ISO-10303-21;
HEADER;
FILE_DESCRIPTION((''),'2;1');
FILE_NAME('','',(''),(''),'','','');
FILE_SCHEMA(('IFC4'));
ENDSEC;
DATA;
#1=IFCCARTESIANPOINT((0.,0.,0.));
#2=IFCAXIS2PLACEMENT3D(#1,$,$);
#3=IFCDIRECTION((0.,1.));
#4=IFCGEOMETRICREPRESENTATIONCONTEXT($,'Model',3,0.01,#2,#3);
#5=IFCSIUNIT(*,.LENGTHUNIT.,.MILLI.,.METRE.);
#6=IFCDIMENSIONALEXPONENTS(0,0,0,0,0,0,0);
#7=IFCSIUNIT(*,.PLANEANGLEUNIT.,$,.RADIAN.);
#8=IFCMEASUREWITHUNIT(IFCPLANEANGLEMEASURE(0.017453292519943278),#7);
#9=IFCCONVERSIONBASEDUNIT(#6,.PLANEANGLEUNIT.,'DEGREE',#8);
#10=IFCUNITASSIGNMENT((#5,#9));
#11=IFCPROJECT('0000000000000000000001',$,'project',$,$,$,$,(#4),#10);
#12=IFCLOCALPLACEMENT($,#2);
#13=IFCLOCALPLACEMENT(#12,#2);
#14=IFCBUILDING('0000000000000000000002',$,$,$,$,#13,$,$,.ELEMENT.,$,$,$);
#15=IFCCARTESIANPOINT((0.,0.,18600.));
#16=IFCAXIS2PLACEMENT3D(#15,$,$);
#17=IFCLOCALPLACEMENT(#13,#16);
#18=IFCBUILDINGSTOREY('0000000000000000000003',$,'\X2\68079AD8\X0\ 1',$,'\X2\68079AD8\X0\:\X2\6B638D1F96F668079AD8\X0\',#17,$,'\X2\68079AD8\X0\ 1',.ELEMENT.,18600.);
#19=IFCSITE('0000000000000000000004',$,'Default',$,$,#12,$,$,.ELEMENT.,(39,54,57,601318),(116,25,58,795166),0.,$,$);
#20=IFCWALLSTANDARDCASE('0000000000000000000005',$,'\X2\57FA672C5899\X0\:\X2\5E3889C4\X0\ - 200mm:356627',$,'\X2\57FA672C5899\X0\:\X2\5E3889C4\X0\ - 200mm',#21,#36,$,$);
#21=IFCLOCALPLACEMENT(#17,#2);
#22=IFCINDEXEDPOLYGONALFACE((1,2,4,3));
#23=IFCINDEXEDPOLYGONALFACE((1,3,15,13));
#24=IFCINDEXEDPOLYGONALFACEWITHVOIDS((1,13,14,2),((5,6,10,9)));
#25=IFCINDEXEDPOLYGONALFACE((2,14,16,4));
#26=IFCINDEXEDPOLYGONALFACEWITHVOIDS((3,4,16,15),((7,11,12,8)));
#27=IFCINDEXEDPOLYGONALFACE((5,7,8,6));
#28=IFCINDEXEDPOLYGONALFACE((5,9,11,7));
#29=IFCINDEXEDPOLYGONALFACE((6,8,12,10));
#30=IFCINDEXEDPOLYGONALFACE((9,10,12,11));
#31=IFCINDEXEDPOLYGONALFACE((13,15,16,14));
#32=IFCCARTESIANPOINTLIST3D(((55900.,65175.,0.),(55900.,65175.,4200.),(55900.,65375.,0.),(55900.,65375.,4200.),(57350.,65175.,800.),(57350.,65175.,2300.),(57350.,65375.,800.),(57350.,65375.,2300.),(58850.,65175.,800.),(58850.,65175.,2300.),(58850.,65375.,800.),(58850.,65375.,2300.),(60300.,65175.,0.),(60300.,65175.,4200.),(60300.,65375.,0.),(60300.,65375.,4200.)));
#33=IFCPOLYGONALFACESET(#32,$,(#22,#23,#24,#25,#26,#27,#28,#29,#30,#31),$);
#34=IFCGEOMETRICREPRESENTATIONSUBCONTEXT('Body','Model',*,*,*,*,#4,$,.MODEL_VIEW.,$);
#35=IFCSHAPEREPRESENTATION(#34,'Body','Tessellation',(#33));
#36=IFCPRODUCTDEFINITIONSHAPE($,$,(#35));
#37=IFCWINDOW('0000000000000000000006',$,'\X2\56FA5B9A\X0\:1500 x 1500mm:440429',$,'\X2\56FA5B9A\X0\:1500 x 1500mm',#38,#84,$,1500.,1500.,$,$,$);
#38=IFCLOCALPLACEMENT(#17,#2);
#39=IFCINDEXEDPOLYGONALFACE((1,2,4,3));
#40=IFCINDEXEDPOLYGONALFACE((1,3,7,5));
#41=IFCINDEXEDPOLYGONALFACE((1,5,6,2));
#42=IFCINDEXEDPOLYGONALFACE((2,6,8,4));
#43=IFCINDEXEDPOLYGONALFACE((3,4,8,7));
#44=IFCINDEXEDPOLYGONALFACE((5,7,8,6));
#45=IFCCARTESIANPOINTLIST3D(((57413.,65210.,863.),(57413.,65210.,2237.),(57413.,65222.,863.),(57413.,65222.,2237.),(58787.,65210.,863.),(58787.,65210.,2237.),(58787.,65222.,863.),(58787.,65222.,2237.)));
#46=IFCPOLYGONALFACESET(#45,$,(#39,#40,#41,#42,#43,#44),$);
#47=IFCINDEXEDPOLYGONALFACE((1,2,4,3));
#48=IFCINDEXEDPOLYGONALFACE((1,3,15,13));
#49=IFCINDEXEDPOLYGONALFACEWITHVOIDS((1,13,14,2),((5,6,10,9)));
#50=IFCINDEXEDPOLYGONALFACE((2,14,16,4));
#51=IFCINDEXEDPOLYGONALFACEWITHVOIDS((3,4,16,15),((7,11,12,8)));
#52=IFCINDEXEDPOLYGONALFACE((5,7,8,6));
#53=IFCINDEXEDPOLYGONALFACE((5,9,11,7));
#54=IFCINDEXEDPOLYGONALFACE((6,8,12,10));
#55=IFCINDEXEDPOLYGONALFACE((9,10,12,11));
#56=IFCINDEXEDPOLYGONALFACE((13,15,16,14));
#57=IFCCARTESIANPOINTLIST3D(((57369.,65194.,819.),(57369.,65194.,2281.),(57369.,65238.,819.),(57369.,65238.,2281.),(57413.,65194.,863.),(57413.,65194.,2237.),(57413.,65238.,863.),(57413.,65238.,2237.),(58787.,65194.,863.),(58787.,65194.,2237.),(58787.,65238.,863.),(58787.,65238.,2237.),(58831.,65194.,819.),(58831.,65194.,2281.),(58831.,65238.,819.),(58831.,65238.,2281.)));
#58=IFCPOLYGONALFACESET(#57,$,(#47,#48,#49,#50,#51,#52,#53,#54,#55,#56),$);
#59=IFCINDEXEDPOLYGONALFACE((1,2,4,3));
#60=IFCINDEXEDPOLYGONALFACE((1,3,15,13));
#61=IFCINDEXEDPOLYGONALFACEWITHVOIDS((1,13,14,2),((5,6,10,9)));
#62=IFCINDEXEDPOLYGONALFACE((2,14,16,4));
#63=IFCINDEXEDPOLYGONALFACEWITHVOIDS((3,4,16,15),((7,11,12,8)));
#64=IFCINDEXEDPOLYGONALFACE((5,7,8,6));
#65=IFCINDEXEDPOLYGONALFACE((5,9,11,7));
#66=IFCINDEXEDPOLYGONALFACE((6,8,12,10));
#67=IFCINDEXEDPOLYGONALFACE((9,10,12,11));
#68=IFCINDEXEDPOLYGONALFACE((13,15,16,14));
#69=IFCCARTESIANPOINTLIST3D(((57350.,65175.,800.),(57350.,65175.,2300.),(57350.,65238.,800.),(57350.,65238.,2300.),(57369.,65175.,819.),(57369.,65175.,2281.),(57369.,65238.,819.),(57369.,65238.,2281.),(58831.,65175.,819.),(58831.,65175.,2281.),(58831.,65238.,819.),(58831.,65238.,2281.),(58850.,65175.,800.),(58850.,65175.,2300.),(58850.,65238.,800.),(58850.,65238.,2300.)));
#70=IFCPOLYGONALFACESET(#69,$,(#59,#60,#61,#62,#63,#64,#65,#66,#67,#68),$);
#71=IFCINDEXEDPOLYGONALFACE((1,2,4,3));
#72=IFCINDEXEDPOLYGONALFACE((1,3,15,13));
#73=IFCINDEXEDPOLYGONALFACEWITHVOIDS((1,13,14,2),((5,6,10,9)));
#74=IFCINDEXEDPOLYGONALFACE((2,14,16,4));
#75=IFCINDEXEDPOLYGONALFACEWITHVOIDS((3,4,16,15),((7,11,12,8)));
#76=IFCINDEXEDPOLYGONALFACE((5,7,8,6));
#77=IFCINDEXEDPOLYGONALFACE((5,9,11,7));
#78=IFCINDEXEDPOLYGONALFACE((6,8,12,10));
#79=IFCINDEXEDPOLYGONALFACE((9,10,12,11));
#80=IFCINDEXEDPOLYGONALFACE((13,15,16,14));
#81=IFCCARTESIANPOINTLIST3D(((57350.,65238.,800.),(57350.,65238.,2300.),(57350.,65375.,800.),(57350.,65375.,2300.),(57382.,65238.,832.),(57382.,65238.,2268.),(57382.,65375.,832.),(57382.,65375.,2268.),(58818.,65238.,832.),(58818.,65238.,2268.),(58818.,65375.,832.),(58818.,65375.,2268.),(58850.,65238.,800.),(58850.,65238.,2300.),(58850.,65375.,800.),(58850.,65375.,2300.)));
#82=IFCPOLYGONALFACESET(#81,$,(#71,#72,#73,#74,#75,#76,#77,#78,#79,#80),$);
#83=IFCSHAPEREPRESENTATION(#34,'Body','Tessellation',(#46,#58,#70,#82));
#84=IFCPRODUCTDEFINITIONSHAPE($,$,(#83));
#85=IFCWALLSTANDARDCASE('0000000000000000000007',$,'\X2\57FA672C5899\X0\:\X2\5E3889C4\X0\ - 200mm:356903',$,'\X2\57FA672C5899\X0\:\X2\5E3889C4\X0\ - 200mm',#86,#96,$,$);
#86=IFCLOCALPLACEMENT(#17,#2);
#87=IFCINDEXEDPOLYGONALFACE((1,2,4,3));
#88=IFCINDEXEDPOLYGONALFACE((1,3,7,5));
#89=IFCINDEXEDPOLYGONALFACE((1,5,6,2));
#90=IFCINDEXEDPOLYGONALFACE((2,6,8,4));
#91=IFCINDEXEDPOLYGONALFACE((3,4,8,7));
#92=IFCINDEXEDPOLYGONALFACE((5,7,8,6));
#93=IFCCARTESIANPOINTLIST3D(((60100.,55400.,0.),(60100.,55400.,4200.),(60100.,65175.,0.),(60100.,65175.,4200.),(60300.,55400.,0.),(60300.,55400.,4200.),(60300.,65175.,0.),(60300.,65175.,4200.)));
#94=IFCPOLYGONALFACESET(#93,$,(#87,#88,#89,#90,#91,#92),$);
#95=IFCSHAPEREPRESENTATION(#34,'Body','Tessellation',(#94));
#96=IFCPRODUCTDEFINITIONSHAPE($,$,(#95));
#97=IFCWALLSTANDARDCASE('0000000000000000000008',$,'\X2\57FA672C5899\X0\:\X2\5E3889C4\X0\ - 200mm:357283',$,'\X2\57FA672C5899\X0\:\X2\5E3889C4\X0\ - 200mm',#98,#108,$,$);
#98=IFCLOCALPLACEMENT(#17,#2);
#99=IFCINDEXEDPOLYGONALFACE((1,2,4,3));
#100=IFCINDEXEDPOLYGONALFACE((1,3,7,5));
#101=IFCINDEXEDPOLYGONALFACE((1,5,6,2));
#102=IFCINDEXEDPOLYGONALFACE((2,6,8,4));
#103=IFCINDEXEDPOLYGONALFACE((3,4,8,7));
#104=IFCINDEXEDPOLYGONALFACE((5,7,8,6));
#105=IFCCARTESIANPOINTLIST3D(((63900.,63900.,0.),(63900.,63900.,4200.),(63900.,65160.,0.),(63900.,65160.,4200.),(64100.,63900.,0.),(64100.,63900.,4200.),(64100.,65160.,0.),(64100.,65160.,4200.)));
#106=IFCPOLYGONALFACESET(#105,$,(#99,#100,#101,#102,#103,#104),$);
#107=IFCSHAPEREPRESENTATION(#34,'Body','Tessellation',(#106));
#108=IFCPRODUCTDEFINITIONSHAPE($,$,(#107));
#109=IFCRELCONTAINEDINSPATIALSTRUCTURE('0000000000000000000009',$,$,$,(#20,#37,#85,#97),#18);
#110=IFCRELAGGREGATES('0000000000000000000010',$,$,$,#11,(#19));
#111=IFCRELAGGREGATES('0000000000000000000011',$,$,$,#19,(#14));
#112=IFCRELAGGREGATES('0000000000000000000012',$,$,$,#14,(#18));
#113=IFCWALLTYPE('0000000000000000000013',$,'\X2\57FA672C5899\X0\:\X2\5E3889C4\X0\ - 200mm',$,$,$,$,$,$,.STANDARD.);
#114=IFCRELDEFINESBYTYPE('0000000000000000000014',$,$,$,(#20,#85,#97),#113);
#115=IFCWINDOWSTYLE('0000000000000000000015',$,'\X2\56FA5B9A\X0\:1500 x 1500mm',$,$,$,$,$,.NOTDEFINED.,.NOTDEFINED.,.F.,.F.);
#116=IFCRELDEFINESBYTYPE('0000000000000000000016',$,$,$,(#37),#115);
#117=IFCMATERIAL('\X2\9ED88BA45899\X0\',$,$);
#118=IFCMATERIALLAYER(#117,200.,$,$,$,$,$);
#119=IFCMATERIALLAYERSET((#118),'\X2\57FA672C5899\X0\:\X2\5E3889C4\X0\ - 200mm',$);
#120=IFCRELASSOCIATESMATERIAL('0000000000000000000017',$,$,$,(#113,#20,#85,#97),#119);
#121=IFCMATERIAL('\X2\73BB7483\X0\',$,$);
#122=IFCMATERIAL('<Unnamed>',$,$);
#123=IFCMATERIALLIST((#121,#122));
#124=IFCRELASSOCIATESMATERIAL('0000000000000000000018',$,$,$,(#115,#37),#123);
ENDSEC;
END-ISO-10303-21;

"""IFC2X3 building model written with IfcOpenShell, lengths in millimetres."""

from ifc_helpers import new_model, entity, si_unit, converted_unit, direction, frame, frame_2d, origin, place, context, subcontext, project, spatial, polyline, rectangle, outline, extrude, source, transform, mapped, material, material_list, layer, layer_set, layer_usage, type_object, type_shapes, element, fill, save


model = new_model("IFC2X3")

# Units and contexts
model_context = context("Model", 3, precision=0.01, world=origin(), true_north=direction((0.0, 1.0)))
body_context = subcontext(model_context, "Body", "Model", "MODEL_VIEW")
ifc_project = project(units=[si_unit("LENGTHUNIT", "METRE", prefix="MILLI"), converted_unit("PLANEANGLEUNIT", "DEGREE", entity("IfcPlaneAngleMeasure", 0.017453292519943278), si_unit("PLANEANGLEUNIT", "RADIAN"), dimensions=[0, 0, 0, 0, 0, 0, 0])], contexts=[model_context])

# Site, building, storey
site_placement = place(None, origin())
site = spatial("IfcSite", under=ifc_project, at=site_placement, Name="Default", CompositionType="ELEMENT", RefLatitude=(39, 54, 57, 601318), RefLongitude=(116, 25, 58, 795166), RefElevation=0.0)
building_placement = place(site_placement, origin())
building = spatial("IfcBuilding", under=site, at=building_placement, CompositionType="ELEMENT")
storey_placement = place(building_placement, frame((0.0, 0.0, 18600.0)))
storey = spatial("IfcBuildingStorey", under=building, at=storey_placement, Name="标高 1", ObjectType="标高:正负零标高", LongName="标高 1", CompositionType="ELEMENT", Elevation=18600.0)

# Shared definitions
ifc_material_1 = material(Name="默认墙")
ifc_layer = layer(ifc_material_1, 200.0)
ifc_layer_set = layer_set([ifc_layer], Name="基本墙:常规 - 200mm")
wall_type = type_object("IfcWallType", Name="基本墙:常规 - 200mm", PredefinedType="STANDARD", material=ifc_layer_set)

# Wall, opening, window
ifc_layer_usage_1 = layer_usage(ifc_layer_set, "AXIS2", "NEGATIVE", 100.0)
wall_1_placement = place(storey_placement, frame((55900.0, 65275.0, 0.0)))
wall_1 = element("IfcWallStandardCase", 1, at=wall_1_placement, inside=storey, type_object=wall_type, material=ifc_layer_usage_1, Name="基本墙:常规 - 200mm:356627", ObjectType="基本墙:常规 - 200mm", context=body_context, shape_type="SweptSolid", body=[
    extrude(rectangle(XDim=4400.0, YDim=200.0, at=frame_2d((2200.0, 0.0), x_axis=(-1.0, 0.0))), origin(), (0.0, 0.0, 1.0), 4200.0),
])
opening_placement = place(wall_1_placement, frame((2950.0, 100.0, 800.0)))
opening = element("IfcOpeningElement", 2, at=opening_placement, cuts=wall_1, ObjectType="Opening", context=body_context, shape_type="SweptSolid", body=[
    extrude(rectangle(XDim=1500.0, YDim=1500.0, at=frame_2d((750.0, 750.0), x_axis=(1.0, 0.0))), frame((0.0, 0.0, 0.0), z_axis=(0.0, -1.0, 0.0), x_axis=(0.0, 0.0, 1.0)), (0.0, 0.0, 1.0), 200.0),
])
ifc_material_2 = material(Name="玻璃")
ifc_material_3 = material(Name="<Unnamed>")
ifc_material_list = material_list([ifc_material_2, ifc_material_3])
window_style = type_object("IfcWindowStyle", Name="固定:1500 x 1500mm", ConstructionType="NOTDEFINED", OperationType="NOTDEFINED", ParameterTakesPrecedence=False, Sizeable=False, material=ifc_material_list)
shared_shape_1 = source(origin(), body_context, "Body", "SweptSolid", [
    extrude(rectangle(XDim=12.0, YDim=1374.0, at=frame_2d((0.0, 0.0), x_axis=(1.0, 0.0))), frame((750.0, 159.0, 63.0), z_axis=(0.0, 0.0, 1.0), x_axis=(0.0, -1.0, 0.0)), (0.0, 0.0, 1.0), 1374.0),
    extrude(outline(polyline([(-731.0, -731.0), (731.0, -731.0), (731.0, 731.0), (-731.0, 731.0), (-731.0, -731.0)]), holes=[polyline([(-687.0, -687.0), (-687.0, 687.0), (687.0, 687.0), (687.0, -687.0), (-687.0, -687.0)])]), frame((750.0, 137.0, 750.0), z_axis=(0.0, 1.0, 0.0), x_axis=(1.0, 0.0, 0.0)), (0.0, 0.0, 1.0), 44.0),
    extrude(outline(polyline([(-750.0, -750.0), (750.0, -750.0), (750.0, 750.0), (-750.0, 750.0), (-750.0, -750.0)]), holes=[polyline([(-731.0, -731.0), (-731.0, 731.0), (731.0, 731.0), (731.0, -731.0), (-731.0, -731.0)])]), frame((750.0, 137.0, 750.0), z_axis=(0.0, 1.0, 0.0), x_axis=(1.0, 0.0, 0.0)), (0.0, 0.0, 1.0), 63.0),
    extrude(outline(polyline([(-750.0, -750.0), (750.0, -750.0), (750.0, 750.0), (-750.0, 750.0), (-750.0, -750.0)]), holes=[polyline([(-718.0, -718.0), (-718.0, 718.0), (718.0, 718.0), (718.0, -718.0), (-718.0, -718.0)])]), frame((750.0, 0.0, 750.0), z_axis=(0.0, 1.0, 0.0), x_axis=(1.0, 0.0, 0.0)), (0.0, 0.0, 1.0), 137.0),
])
type_shapes(window_style, [shared_shape_1])
window_placement = place(opening_placement, frame((0.0, 0.0, 0.0), z_axis=(0.0, 0.0, 1.0), x_axis=(-1.0, 0.0, 0.0)))
window = element("IfcWindow", 3, at=window_placement, inside=storey, type_object=window_style, material=ifc_material_list, Name="固定:1500 x 1500mm:440429", ObjectType="固定:1500 x 1500mm", OverallHeight=1500.0, OverallWidth=1500.0, context=body_context, shape_type="MappedRepresentation", body=[
    mapped(shared_shape_1, transform((0.0, 0.0, 0.0), scale=1.0)),
])
fill(opening, window)

# Walls
ifc_layer_usage_2 = layer_usage(ifc_layer_set, "AXIS2", "NEGATIVE", 100.0)
wall_2_placement = place(storey_placement, frame((60200.0, 65175.0, 0.0), z_axis=(0.0, 0.0, 1.0), x_axis=(0.0, -1.0, 0.0)))
element("IfcWallStandardCase", 4, at=wall_2_placement, inside=storey, type_object=wall_type, material=ifc_layer_usage_2, Name="基本墙:常规 - 200mm:356903", ObjectType="基本墙:常规 - 200mm", context=body_context, shape_type="SweptSolid", body=[
    extrude(rectangle(XDim=9775.0, YDim=200.0, at=frame_2d((4887.5, 0.0), x_axis=(-1.0, 0.0))), origin(), (0.0, 0.0, 1.0), 4200.0),
])
ifc_layer_usage_3 = layer_usage(ifc_layer_set, "AXIS2", "NEGATIVE", 100.0)
wall_3_placement = place(storey_placement, frame((64000.0, 65160.0, 0.0), z_axis=(0.0, 0.0, 1.0), x_axis=(0.0, -1.0, 0.0)))
element("IfcWallStandardCase", 5, at=wall_3_placement, inside=storey, type_object=wall_type, material=ifc_layer_usage_3, Name="基本墙:常规 - 200mm:357283", ObjectType="基本墙:常规 - 200mm", context=body_context, shape_type="SweptSolid", body=[
    extrude(rectangle(XDim=1260.0, YDim=200.0, at=frame_2d((630.0, 0.0), x_axis=(-1.0, 0.0))), origin(), (0.0, 0.0, 1.0), 4200.0),
])

save(model, "model.ifc")
